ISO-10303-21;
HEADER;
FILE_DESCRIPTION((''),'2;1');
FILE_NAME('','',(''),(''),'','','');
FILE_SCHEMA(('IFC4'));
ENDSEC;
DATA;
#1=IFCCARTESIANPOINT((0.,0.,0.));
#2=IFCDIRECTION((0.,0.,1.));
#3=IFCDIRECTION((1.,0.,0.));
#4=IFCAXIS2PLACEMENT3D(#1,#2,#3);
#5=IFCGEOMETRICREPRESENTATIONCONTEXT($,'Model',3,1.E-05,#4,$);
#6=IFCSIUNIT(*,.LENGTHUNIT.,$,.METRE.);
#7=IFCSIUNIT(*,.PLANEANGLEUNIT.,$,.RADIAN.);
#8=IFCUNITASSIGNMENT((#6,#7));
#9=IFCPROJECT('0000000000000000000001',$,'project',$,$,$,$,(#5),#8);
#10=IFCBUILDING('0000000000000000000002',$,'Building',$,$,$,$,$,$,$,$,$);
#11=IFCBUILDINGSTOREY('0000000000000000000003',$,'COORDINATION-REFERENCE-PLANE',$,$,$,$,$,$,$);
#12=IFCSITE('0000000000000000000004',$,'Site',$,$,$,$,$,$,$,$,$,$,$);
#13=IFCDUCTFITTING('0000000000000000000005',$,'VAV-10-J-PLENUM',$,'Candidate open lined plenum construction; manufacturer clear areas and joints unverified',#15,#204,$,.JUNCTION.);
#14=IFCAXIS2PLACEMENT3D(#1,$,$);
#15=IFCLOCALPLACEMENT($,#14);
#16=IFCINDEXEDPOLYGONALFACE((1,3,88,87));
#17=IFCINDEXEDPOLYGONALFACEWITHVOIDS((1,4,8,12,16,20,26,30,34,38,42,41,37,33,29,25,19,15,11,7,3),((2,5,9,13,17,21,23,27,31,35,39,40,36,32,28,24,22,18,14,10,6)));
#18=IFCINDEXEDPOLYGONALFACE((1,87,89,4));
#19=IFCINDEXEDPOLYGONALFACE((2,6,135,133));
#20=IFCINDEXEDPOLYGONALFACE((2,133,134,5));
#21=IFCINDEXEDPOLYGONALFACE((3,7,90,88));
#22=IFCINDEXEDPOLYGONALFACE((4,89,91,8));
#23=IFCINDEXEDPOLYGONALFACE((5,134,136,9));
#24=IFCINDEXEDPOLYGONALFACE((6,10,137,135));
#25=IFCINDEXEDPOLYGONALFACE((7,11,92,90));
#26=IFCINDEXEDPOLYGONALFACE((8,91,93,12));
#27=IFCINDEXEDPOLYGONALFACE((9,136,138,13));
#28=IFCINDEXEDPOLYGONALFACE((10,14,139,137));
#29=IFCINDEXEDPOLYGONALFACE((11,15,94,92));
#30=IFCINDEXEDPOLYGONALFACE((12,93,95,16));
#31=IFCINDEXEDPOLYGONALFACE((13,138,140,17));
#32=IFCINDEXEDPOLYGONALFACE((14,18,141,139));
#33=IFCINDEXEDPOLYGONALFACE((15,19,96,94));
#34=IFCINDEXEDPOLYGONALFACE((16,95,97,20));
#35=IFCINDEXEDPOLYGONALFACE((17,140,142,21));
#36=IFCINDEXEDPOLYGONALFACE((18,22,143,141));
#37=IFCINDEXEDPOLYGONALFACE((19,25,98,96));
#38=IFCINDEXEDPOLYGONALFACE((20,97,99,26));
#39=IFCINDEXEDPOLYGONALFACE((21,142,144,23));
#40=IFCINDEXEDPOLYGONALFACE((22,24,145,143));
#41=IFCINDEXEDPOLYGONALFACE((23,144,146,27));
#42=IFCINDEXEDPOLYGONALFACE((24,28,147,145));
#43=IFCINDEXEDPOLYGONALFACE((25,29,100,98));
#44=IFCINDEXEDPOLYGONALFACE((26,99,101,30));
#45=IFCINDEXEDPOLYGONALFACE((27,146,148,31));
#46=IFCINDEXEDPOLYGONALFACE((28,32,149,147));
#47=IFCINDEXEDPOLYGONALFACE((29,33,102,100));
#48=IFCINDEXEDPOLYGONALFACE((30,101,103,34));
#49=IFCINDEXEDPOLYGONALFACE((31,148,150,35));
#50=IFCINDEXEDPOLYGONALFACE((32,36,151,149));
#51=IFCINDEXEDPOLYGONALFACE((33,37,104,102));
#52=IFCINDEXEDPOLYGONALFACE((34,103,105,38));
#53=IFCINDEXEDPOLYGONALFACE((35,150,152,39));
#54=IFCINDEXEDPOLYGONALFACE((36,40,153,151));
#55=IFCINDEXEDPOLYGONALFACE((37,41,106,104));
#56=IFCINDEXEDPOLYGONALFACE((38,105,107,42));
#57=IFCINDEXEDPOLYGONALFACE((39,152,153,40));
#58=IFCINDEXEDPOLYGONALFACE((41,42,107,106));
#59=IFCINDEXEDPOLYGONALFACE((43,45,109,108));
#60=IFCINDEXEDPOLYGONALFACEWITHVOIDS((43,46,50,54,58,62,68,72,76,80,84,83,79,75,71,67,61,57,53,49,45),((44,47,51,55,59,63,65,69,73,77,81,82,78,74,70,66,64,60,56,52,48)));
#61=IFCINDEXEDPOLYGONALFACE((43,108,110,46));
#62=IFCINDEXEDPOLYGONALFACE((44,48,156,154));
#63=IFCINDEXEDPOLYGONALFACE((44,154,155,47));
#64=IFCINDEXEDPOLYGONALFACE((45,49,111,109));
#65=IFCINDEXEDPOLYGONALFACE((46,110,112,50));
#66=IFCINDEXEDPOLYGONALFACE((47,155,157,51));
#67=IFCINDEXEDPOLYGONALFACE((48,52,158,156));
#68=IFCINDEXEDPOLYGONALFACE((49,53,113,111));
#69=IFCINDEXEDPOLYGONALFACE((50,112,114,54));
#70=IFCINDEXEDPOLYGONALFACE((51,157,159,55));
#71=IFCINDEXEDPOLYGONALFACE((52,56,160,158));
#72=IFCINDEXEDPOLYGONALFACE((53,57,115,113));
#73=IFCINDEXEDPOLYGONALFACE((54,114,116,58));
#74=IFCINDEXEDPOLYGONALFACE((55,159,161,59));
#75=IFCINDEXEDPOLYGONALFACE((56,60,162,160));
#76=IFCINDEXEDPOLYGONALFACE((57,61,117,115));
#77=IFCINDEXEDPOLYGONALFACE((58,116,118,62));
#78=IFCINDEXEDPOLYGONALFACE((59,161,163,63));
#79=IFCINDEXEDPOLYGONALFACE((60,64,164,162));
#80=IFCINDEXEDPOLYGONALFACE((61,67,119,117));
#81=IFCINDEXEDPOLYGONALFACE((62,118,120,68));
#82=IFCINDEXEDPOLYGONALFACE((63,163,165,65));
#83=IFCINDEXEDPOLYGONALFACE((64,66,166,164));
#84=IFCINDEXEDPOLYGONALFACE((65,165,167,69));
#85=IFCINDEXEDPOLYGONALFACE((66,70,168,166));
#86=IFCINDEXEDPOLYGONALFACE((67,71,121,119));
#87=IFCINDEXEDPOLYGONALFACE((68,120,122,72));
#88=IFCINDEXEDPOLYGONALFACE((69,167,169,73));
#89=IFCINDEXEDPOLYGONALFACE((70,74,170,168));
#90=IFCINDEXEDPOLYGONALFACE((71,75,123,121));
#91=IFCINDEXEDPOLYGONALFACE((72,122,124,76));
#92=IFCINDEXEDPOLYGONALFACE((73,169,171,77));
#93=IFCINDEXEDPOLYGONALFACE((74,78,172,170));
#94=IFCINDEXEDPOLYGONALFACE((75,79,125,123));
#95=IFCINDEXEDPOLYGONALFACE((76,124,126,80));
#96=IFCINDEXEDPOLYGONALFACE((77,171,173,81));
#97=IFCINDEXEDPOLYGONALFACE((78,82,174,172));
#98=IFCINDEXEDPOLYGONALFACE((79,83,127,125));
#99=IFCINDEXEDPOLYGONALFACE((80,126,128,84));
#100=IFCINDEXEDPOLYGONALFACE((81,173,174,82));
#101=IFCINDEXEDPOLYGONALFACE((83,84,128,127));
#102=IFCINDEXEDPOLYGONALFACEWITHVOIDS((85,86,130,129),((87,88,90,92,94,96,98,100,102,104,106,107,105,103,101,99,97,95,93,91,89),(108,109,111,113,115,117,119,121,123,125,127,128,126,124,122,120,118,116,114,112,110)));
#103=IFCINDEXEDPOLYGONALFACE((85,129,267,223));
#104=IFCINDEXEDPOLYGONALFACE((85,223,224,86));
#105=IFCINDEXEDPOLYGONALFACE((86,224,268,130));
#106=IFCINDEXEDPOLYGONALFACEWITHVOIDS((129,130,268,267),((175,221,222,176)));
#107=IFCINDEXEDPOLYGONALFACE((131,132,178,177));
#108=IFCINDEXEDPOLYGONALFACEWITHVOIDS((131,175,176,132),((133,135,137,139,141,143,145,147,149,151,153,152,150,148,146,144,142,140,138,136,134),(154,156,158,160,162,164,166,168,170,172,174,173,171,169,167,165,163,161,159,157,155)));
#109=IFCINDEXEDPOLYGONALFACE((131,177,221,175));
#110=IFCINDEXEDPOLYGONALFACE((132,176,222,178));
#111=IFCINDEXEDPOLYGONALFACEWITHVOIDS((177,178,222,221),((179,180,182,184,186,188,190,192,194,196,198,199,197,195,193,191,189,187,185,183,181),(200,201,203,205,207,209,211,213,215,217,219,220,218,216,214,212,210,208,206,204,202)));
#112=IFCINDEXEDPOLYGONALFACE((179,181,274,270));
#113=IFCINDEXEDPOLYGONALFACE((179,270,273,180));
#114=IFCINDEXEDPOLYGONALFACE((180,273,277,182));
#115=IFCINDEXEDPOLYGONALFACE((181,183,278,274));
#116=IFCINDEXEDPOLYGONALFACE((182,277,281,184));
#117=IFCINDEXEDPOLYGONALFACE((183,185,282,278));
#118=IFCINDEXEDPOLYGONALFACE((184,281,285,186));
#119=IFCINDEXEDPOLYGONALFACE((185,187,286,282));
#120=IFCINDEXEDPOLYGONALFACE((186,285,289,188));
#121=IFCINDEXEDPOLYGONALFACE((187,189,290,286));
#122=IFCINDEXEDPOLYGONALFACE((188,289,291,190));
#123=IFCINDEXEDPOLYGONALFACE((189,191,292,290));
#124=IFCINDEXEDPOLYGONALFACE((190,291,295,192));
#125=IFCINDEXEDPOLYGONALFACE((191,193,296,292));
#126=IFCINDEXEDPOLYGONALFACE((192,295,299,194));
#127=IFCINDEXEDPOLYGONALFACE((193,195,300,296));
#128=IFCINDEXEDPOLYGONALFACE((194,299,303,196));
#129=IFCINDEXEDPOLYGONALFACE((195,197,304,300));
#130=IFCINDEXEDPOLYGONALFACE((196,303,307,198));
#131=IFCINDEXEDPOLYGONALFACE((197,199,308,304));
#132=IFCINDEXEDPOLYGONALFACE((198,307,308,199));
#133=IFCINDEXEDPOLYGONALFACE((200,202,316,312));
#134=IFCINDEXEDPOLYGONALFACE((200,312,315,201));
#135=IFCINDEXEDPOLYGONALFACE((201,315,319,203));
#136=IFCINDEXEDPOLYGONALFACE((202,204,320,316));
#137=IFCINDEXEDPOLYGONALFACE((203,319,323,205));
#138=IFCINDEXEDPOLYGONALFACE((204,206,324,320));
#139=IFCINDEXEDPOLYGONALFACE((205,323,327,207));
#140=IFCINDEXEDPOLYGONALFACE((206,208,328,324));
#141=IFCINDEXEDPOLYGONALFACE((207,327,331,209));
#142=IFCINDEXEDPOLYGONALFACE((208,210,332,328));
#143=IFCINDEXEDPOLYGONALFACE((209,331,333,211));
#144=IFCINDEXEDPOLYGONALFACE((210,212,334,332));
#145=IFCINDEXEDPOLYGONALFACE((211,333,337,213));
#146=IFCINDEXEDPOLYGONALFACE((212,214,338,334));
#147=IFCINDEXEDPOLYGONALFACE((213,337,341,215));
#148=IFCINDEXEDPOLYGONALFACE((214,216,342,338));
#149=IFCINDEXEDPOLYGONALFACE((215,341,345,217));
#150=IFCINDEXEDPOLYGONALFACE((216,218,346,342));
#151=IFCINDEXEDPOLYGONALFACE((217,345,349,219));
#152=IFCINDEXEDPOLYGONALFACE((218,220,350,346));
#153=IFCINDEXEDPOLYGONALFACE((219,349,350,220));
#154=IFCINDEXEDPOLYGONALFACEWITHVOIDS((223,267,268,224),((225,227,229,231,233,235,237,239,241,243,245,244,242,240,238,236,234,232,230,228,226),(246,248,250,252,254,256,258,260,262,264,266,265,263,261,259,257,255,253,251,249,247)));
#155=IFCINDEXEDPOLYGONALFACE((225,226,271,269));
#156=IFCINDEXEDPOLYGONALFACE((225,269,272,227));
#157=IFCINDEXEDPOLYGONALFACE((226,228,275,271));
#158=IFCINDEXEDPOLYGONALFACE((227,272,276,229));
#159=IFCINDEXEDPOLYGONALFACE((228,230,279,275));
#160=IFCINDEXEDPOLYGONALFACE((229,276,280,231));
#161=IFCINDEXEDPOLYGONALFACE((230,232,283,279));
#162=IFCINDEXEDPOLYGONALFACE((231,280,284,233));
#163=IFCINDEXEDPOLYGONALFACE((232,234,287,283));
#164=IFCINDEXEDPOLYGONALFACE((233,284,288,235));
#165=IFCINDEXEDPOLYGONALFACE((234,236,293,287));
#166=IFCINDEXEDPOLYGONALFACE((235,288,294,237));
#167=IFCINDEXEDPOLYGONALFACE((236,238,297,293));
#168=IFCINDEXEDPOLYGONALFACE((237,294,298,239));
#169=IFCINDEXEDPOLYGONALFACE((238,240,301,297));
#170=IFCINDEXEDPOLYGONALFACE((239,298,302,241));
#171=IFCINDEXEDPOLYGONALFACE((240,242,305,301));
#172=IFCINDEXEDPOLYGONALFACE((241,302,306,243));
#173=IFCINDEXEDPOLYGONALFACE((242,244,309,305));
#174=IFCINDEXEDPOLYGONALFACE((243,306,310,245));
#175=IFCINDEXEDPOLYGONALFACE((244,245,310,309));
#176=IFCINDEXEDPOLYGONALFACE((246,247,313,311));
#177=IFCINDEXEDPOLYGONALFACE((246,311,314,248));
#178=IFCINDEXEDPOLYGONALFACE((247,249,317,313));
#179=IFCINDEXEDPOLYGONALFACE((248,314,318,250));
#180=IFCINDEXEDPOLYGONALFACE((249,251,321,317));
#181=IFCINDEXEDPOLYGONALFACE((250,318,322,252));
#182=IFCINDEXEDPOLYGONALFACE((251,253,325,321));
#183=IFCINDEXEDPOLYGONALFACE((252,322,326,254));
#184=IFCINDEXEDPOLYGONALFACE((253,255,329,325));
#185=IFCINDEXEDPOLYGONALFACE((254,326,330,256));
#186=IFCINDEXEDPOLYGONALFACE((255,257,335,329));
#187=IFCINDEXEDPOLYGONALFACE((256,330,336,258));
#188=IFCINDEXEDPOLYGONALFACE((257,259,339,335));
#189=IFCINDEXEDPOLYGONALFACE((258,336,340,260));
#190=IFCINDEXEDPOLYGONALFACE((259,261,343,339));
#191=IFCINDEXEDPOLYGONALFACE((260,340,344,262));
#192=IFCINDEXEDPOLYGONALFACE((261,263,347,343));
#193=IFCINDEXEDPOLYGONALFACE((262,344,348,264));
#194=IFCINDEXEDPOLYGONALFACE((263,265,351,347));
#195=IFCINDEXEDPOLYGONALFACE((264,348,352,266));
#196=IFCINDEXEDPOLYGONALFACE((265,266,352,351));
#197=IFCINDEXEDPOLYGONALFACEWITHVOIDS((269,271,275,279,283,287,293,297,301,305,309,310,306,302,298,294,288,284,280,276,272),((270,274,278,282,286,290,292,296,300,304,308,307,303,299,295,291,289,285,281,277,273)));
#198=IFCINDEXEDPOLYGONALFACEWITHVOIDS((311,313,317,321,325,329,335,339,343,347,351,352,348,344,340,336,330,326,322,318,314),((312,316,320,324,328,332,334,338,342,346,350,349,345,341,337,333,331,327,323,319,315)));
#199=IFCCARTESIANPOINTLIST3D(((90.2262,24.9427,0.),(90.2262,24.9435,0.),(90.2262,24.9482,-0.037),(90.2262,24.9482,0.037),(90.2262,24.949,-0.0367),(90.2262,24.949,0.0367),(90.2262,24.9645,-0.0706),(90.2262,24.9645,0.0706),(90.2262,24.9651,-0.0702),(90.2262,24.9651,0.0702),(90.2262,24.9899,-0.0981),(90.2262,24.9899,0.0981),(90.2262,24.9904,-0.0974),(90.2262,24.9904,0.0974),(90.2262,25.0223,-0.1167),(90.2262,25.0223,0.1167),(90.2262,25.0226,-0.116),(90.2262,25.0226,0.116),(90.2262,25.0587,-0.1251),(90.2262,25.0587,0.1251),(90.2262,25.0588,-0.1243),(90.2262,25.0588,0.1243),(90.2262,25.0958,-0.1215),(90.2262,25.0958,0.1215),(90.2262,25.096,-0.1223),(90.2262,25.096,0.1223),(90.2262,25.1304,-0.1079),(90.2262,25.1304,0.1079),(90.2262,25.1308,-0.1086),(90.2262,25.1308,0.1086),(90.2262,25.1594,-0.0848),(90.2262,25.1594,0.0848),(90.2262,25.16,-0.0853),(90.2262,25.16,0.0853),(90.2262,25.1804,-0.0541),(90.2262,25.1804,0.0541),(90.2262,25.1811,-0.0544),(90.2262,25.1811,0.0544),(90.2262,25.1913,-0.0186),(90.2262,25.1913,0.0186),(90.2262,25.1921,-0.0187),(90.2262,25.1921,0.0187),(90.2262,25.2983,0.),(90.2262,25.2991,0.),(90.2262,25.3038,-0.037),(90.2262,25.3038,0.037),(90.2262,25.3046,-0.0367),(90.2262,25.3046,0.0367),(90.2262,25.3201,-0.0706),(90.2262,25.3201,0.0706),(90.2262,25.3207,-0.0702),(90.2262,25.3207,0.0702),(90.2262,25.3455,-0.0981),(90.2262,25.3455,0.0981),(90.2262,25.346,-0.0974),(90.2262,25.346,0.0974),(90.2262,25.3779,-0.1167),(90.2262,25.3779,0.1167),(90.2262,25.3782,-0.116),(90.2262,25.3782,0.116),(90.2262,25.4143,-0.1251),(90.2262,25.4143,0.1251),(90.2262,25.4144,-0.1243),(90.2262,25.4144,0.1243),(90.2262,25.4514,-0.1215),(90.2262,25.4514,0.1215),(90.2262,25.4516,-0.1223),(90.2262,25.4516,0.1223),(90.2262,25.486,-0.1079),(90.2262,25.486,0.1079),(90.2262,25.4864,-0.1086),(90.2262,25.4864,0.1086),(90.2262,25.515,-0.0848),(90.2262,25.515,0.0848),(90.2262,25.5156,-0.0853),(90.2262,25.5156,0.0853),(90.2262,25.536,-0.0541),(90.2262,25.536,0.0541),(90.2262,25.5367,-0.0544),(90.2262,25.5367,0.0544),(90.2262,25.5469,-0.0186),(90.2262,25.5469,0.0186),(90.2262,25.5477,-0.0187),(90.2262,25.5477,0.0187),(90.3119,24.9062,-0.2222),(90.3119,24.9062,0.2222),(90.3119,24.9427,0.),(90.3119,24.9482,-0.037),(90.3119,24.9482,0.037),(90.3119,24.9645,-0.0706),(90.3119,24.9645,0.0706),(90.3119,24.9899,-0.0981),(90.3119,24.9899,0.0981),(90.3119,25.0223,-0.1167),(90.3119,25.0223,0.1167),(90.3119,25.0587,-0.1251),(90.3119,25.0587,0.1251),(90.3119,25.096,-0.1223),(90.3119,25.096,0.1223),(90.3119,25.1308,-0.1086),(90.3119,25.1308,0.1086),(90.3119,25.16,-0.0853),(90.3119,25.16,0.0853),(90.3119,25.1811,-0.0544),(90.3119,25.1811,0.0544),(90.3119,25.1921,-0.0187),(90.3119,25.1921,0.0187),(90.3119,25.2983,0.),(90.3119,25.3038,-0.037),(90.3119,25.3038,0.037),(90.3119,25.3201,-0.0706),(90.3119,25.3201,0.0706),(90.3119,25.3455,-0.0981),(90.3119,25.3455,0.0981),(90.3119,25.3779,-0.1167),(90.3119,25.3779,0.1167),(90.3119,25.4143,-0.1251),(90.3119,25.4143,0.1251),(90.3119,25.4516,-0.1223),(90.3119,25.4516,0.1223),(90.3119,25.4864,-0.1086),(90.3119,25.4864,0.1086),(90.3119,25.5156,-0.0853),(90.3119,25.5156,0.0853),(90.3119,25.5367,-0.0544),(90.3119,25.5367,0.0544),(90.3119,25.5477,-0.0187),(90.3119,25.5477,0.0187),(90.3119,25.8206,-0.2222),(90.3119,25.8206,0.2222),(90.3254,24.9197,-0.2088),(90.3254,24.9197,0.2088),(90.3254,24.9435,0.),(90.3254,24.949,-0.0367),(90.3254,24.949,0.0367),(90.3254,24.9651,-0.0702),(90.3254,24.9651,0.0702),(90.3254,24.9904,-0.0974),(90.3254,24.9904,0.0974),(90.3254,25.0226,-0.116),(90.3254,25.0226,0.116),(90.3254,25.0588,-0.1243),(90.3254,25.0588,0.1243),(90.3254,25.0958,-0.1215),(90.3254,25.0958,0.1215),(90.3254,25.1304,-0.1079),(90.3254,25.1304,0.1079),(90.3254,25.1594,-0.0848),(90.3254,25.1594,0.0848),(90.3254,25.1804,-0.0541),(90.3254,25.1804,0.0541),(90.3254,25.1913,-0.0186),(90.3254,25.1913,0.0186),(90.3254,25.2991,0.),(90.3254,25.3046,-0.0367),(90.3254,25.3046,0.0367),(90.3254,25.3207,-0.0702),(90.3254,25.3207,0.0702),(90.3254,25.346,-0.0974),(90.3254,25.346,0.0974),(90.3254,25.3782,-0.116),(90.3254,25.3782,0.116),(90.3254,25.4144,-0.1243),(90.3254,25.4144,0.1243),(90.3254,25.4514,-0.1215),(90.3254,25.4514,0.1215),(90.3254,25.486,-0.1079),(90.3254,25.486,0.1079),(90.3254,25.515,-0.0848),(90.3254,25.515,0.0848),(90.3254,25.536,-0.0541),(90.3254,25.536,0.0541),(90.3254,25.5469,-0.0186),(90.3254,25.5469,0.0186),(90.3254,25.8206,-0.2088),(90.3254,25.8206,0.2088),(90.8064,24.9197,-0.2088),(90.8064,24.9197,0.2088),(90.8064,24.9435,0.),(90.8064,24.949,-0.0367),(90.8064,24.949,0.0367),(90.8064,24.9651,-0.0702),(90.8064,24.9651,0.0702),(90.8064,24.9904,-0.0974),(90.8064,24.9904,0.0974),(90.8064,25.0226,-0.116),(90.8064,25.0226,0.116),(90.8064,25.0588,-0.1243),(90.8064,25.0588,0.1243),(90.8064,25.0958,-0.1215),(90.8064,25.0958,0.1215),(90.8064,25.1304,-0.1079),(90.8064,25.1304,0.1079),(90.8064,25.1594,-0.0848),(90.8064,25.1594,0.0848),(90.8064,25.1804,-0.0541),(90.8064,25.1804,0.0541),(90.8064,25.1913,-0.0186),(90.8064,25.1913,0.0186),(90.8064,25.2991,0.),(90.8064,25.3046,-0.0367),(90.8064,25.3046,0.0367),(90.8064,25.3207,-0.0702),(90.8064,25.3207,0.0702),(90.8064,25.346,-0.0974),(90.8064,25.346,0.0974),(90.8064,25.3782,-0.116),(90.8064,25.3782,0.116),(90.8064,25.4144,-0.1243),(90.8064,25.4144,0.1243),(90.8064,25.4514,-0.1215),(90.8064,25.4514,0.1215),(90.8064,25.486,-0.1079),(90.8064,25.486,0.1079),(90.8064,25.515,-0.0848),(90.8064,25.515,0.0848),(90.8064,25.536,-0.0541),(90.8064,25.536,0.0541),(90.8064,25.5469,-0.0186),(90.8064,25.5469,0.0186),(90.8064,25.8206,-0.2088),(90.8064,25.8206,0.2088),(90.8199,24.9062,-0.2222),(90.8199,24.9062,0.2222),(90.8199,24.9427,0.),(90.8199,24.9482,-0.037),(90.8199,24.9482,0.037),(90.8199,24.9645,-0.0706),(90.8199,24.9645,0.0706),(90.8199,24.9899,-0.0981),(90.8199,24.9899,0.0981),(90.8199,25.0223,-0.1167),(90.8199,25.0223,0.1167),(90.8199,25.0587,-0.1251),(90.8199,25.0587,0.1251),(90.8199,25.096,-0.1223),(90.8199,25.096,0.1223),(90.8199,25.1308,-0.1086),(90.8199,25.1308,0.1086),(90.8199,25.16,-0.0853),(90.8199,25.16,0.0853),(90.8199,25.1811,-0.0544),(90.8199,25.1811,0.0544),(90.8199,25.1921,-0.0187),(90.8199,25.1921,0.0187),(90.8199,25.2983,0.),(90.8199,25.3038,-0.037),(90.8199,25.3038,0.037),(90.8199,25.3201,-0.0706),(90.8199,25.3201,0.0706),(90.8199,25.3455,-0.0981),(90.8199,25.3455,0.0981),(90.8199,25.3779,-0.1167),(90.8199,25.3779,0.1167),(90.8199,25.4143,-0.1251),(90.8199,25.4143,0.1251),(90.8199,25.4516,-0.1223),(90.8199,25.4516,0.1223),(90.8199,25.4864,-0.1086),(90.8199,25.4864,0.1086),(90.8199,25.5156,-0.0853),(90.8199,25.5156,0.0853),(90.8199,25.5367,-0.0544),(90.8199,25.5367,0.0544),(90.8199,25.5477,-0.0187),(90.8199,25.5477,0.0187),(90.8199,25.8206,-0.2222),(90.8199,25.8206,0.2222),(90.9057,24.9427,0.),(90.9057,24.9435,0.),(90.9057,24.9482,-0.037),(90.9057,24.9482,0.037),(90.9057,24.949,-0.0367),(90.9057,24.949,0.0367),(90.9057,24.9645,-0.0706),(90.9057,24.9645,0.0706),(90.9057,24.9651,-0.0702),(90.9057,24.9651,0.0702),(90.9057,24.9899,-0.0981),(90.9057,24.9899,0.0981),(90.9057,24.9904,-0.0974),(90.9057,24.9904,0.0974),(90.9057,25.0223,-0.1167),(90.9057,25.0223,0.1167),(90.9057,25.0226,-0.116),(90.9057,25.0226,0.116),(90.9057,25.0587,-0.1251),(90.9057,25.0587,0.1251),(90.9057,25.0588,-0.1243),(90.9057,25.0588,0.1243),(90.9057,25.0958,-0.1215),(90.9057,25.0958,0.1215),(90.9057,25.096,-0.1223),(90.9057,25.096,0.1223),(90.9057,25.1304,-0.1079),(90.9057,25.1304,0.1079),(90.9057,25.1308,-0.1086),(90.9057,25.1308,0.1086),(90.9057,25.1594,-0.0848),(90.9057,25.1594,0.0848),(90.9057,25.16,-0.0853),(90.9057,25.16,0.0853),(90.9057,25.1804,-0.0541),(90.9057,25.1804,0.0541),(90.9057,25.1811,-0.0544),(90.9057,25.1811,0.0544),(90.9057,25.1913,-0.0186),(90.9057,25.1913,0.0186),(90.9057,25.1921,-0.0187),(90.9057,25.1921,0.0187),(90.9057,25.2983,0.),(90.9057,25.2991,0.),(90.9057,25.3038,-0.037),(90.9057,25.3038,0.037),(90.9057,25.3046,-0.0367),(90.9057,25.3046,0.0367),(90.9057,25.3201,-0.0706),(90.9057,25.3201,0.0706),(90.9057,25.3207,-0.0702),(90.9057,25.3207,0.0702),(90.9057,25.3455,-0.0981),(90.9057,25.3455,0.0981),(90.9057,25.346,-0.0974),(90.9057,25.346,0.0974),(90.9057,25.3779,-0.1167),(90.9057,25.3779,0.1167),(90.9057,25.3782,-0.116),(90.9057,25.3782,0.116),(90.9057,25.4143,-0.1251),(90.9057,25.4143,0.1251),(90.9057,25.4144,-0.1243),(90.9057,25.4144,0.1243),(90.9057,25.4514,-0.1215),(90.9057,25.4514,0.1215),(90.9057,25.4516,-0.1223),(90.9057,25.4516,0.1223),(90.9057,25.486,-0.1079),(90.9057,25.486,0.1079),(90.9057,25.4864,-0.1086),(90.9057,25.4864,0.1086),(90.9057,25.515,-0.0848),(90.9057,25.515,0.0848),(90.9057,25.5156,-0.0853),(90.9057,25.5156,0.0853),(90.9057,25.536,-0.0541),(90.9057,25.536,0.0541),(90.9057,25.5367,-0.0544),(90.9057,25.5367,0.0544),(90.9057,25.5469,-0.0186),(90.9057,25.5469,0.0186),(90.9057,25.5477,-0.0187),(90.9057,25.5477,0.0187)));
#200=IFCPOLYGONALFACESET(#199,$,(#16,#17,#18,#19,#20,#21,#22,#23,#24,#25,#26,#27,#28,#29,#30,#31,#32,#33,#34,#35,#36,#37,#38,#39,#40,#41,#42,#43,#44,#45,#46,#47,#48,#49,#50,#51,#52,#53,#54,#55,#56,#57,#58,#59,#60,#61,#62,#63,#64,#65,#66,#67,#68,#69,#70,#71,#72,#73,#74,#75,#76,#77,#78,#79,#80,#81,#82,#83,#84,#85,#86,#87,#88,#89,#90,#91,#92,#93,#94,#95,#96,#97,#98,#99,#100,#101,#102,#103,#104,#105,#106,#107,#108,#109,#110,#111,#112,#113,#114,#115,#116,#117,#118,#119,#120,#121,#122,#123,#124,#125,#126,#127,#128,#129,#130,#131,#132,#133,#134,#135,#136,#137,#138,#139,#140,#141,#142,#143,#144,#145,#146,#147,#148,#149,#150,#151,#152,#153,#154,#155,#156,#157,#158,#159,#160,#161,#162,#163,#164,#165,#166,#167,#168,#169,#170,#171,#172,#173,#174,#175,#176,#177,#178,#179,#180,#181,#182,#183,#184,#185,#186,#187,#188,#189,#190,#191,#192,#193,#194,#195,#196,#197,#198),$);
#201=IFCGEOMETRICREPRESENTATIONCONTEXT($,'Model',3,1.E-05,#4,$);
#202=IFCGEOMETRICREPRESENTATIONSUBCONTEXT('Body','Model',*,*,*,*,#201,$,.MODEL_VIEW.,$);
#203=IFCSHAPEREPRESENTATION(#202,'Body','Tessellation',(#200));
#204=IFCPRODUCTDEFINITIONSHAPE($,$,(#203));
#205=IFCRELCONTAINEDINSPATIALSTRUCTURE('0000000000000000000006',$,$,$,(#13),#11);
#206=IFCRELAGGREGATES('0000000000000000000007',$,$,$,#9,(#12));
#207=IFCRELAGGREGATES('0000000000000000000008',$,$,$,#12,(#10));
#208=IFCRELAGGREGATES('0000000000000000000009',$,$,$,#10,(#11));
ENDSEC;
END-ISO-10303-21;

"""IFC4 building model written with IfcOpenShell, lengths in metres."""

from ifc_helpers import new_model, si_unit, frame, origin_with_axes, place, context, subcontext, project, spatial, rectangle, circle, extrude, boolean, element, save


model = new_model("IFC4")

# Units and contexts
model_context_1 = context("Model", 3, precision=1e-05, world=origin_with_axes())
model_context_2 = context("Model", 3, precision=1e-05, world=origin_with_axes())
body_context_1 = subcontext(model_context_2, "Body", "Model", "MODEL_VIEW")
ifc_project = project(units=[si_unit("LENGTHUNIT", "METRE"), si_unit("PLANEANGLEUNIT", "RADIAN")], contexts=[model_context_1])

# Site, building, storey
site = spatial("IfcSite", under=ifc_project, Name="Site")
building = spatial("IfcBuilding", under=site, Name="Building")
storey = spatial("IfcBuildingStorey", under=building, Name="COORDINATION-REFERENCE-PLANE")

# Duct fitting
duct_fitting_1_placement = place(None, frame((90.3119, 24.9062, -0.2223), z_axis=(0.0, 0.0, 1.0), x_axis=(1.0, 0.0, 0.0)))
solid_1 = boolean("UNION", boolean("UNION", boolean("UNION", boolean("UNION", extrude(rectangle(XDim=0.481, YDim=0.4175), frame((0.254, 0.9244, 0.2223), z_axis=(0.0, -1.0, 0.0), x_axis=(1.0, 0.0, 0.0)), (0.0, 0.0, 1.0), 0.9109), extrude(circle(Radius=0.1246), frame((0.0235, 0.5175, 0.2223), z_axis=(-1.0, 0.0, 0.0), x_axis=(0.0, -1.0, 0.0)), (0.0, 0.0, 1.0), 0.1192)), extrude(circle(Radius=0.1246), frame((0.4845, 0.5175, 0.2223), z_axis=(1.0, 0.0, 0.0), x_axis=(0.0, -1.0, 0.0)), (0.0, 0.0, 1.0), 0.1192)), extrude(circle(Radius=0.1246), frame((0.0235, 0.1619, 0.2223), z_axis=(-1.0, 0.0, 0.0), x_axis=(0.0, -1.0, 0.0)), (0.0, 0.0, 1.0), 0.1192)), extrude(circle(Radius=0.1246), frame((0.4845, 0.1619, 0.2223), z_axis=(1.0, 0.0, 0.0), x_axis=(0.0, -1.0, 0.0)), (0.0, 0.0, 1.0), 0.1192))
element("IfcDuctFitting", 1, at=duct_fitting_1_placement, inside=storey, Name="VAV-10-J-PLENUM", ObjectType="Candidate open lined plenum construction; manufacturer clear areas and joints unverified", PredefinedType="JUNCTION", context=body_context_1, shape_type="CSG", body=[
    boolean("DIFFERENCE", boolean("UNION", boolean("UNION", boolean("UNION", boolean("UNION", extrude(rectangle(XDim=0.508, YDim=0.4445), frame((0.254, 0.9144, 0.2223), z_axis=(0.0, -1.0, 0.0), x_axis=(1.0, 0.0, 0.0)), (0.0, 0.0, 1.0), 0.9144), extrude(circle(Radius=0.1254), frame((0.0235, 0.5175, 0.2223), z_axis=(-1.0, 0.0, 0.0), x_axis=(0.0, -1.0, 0.0)), (0.0, 0.0, 1.0), 0.1092)), extrude(circle(Radius=0.1254), frame((0.4845, 0.5175, 0.2223), z_axis=(1.0, 0.0, 0.0), x_axis=(0.0, -1.0, 0.0)), (0.0, 0.0, 1.0), 0.1092)), extrude(circle(Radius=0.1254), frame((0.0235, 0.1619, 0.2223), z_axis=(-1.0, 0.0, 0.0), x_axis=(0.0, -1.0, 0.0)), (0.0, 0.0, 1.0), 0.1092)), extrude(circle(Radius=0.1254), frame((0.4845, 0.1619, 0.2223), z_axis=(1.0, 0.0, 0.0), x_axis=(0.0, -1.0, 0.0)), (0.0, 0.0, 1.0), 0.1092)), solid_1),
])

save(model, "model.ifc")
